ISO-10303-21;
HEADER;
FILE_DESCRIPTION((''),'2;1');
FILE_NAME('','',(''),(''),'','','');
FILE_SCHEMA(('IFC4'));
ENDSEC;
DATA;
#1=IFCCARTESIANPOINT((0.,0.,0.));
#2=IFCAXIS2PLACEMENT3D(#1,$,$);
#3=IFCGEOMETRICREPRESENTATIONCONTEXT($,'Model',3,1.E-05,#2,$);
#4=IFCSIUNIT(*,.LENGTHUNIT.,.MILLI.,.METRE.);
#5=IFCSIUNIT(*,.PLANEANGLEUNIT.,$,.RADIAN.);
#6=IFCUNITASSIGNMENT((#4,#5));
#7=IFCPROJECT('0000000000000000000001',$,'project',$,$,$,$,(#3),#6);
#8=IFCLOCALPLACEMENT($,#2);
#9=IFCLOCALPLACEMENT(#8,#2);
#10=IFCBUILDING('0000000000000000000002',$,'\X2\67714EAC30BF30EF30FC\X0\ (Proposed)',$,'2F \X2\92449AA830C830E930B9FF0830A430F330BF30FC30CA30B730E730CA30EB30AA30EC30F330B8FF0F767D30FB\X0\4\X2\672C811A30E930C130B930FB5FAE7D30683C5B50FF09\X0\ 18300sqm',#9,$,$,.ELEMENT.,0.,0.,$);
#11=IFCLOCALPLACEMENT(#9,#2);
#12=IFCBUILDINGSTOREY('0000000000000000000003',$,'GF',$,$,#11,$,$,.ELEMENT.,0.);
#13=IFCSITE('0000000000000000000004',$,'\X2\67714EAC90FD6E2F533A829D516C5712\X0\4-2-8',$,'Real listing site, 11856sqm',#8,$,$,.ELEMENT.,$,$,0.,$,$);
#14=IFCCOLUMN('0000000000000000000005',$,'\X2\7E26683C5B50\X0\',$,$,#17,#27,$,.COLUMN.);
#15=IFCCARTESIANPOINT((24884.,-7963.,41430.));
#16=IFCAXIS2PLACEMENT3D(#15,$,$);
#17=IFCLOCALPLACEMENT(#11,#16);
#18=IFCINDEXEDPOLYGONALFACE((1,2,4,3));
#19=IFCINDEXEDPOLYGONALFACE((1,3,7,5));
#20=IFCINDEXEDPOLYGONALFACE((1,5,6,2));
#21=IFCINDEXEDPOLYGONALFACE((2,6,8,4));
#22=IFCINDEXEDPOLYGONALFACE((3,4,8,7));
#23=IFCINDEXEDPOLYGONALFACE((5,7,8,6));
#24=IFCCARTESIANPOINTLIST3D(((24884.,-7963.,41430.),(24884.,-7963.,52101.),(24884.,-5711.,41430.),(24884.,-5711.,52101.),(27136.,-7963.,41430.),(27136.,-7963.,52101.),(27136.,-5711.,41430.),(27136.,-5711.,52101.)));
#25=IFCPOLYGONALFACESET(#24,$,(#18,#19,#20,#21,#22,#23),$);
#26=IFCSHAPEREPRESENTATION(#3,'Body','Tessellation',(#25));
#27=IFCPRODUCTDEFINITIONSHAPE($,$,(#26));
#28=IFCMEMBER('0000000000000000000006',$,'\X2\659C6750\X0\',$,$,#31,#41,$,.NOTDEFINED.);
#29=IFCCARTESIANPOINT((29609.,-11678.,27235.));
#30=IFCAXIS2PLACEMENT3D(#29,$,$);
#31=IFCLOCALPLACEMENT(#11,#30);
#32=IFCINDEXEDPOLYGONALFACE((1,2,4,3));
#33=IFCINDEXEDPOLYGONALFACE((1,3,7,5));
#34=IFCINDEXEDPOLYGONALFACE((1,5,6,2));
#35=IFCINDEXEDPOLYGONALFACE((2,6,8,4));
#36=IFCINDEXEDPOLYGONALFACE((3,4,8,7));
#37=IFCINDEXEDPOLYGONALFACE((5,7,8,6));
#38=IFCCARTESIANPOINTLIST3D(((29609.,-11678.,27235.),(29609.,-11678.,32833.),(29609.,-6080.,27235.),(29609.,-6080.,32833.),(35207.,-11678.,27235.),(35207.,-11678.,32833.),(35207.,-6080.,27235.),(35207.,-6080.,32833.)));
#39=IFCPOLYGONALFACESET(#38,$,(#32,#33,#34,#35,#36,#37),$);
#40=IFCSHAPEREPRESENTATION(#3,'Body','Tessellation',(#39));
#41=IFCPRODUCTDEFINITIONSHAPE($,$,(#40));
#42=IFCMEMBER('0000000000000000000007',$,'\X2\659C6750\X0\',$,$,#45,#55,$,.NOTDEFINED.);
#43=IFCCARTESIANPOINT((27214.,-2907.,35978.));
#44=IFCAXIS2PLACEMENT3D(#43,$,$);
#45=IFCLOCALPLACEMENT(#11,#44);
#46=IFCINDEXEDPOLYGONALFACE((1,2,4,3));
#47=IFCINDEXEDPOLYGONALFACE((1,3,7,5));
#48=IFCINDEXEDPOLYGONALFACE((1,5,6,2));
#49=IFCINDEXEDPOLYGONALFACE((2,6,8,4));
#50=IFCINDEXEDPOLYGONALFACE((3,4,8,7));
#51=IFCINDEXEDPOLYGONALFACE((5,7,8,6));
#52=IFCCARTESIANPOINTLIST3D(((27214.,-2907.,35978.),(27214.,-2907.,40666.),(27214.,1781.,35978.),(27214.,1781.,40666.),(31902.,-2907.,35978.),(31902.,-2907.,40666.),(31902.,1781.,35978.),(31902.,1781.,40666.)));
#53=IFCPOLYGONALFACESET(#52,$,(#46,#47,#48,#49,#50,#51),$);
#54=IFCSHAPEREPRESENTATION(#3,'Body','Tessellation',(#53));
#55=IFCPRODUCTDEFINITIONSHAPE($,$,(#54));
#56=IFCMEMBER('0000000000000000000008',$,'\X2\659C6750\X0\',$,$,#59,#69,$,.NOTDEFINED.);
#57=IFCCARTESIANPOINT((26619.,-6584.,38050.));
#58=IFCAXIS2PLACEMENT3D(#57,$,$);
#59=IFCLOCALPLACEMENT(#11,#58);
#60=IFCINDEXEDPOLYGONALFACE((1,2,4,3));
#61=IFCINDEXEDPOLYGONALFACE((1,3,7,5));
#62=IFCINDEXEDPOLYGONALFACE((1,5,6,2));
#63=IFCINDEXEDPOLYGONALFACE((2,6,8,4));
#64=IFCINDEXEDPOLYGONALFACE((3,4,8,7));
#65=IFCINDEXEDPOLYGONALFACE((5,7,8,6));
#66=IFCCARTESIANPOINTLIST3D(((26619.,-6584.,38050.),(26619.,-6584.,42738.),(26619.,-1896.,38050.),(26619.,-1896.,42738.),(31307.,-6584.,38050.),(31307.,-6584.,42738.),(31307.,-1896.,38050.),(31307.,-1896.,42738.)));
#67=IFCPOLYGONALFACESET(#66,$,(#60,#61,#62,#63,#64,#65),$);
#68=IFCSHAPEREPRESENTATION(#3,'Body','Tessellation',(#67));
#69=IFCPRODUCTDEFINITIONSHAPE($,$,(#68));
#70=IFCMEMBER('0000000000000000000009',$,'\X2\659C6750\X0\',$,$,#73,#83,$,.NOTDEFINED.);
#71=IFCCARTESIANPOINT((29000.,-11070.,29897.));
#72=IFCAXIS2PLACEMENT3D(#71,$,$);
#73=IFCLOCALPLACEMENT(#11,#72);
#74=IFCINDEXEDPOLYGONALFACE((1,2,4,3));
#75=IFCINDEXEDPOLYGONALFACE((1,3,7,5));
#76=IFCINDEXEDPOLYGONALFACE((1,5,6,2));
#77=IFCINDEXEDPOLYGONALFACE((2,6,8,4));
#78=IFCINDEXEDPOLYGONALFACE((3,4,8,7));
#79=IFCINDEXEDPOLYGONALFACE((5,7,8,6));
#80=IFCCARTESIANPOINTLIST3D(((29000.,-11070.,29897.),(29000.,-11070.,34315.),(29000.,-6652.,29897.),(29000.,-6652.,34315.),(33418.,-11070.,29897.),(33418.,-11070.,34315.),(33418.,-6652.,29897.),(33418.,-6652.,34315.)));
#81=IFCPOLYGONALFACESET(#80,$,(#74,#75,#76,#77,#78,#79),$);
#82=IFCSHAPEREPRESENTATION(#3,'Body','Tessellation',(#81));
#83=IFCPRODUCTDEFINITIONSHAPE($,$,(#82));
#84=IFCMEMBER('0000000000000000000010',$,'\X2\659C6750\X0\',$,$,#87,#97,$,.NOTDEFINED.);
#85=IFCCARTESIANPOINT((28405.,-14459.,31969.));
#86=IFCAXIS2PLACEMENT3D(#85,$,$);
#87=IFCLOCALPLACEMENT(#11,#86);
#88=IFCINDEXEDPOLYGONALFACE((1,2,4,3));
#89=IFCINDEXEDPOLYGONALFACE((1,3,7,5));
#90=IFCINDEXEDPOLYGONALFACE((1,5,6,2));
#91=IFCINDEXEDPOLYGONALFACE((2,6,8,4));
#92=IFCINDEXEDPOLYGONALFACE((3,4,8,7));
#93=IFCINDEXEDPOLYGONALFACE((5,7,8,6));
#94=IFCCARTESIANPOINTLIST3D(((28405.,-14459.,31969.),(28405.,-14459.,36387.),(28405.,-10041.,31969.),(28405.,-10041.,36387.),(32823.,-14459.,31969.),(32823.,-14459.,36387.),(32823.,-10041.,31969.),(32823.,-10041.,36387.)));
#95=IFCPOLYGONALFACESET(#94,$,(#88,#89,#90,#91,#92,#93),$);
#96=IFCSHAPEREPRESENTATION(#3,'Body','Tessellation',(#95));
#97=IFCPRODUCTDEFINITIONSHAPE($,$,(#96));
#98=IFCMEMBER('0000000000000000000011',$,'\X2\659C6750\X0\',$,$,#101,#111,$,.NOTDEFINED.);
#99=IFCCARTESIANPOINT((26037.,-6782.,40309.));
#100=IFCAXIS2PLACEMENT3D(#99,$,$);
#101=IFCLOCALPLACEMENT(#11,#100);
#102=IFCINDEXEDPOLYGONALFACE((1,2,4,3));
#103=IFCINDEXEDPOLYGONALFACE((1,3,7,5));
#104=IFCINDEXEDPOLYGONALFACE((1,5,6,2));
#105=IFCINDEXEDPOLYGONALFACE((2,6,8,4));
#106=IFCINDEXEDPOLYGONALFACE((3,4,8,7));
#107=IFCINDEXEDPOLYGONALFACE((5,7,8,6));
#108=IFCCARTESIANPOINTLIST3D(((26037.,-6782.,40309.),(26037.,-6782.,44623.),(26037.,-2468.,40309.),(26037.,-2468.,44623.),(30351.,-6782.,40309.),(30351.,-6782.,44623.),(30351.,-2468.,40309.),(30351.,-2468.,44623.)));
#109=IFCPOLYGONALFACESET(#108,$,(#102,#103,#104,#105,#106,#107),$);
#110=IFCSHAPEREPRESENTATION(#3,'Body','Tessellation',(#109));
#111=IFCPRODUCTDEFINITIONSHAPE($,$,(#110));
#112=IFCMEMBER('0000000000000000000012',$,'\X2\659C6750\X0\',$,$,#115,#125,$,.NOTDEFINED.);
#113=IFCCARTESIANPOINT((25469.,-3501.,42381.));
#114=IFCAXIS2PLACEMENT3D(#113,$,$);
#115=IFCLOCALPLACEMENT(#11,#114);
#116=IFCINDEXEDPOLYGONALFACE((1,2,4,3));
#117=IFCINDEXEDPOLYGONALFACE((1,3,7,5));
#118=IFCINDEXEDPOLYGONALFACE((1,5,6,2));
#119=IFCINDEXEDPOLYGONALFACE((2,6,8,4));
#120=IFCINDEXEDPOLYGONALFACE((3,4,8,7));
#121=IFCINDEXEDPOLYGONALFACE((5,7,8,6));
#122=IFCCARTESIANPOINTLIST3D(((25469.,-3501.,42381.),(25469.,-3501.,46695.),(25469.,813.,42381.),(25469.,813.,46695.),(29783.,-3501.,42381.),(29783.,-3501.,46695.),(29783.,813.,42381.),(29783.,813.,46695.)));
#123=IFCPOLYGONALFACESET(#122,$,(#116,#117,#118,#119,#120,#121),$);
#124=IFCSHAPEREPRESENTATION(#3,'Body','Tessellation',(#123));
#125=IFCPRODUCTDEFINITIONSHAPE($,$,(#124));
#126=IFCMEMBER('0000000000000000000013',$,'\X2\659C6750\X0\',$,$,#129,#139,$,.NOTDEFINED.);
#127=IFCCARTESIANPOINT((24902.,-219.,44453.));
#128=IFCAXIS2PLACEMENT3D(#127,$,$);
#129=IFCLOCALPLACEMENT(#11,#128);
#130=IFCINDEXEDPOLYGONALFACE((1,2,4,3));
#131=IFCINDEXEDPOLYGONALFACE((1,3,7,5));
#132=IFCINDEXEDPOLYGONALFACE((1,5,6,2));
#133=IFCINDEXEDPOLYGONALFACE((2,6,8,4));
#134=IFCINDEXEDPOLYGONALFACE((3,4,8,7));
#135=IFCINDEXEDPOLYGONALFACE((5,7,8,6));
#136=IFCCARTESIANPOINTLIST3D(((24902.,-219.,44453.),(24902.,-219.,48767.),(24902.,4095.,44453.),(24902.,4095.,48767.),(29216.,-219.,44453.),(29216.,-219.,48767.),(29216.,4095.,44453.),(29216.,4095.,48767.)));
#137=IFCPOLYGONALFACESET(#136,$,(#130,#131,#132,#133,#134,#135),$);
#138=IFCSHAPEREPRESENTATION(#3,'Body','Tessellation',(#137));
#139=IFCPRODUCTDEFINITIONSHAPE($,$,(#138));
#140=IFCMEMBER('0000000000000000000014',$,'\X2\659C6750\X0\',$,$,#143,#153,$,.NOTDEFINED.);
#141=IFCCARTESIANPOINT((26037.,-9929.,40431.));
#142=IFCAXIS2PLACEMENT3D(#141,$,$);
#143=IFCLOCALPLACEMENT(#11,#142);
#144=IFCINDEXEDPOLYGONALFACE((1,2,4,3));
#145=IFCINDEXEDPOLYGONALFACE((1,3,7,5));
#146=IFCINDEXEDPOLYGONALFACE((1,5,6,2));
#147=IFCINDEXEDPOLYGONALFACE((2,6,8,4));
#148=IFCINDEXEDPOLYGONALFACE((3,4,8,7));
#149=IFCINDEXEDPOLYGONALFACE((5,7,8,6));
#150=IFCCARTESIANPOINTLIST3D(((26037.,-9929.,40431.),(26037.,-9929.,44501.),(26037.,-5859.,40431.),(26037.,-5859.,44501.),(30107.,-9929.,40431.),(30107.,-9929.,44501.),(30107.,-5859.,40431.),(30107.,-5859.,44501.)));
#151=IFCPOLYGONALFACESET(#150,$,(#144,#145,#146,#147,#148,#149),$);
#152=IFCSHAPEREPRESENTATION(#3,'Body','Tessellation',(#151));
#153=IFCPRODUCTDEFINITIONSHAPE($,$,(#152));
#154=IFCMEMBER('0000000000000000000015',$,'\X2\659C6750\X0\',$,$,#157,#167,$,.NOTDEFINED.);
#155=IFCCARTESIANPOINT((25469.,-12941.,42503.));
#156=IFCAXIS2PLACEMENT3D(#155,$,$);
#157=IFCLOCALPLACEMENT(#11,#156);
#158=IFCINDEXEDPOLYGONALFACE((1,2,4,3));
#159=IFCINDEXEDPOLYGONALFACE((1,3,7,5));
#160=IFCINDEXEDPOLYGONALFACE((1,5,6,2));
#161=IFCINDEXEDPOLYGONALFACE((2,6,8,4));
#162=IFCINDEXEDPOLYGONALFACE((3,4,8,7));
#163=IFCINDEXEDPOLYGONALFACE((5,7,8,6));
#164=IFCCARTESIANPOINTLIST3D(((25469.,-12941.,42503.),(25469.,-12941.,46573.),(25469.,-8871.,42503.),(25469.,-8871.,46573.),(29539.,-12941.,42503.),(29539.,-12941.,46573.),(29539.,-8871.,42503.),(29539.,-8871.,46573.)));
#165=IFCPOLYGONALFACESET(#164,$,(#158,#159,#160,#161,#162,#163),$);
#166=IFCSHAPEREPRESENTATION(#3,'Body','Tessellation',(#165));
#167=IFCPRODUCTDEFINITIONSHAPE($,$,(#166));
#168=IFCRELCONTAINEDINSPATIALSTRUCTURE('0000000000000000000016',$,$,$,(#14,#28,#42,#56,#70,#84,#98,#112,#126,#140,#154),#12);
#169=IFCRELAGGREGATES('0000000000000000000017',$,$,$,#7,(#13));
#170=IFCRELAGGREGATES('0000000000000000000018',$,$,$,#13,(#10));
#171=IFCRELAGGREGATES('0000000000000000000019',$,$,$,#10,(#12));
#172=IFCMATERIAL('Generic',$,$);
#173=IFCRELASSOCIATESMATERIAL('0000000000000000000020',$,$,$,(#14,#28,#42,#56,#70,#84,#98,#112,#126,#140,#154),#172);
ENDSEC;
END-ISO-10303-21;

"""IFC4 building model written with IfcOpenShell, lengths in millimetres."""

from ifc_helpers import new_model, si_unit, frame, frame_2d, origin, place, context, project, spatial, rectangle, extrude, material, element, save


model = new_model("IFC4")

# Units and contexts
model_context = context("Model", 3, precision=1e-05, world=origin())
ifc_project = project(units=[si_unit("LENGTHUNIT", "METRE", prefix="MILLI"), si_unit("PLANEANGLEUNIT", "RADIAN")], contexts=[model_context])

# Site, building, storey
site_placement = place(None, origin())
site = spatial("IfcSite", under=ifc_project, at=site_placement, Name="東京都港区芝公園4-2-8", ObjectType="Real listing site, 11856sqm", CompositionType="ELEMENT", RefElevation=0.0)
building_placement = place(site_placement, origin())
building = spatial("IfcBuilding", under=site, at=building_placement, Name="東京タワー (Proposed)", ObjectType="2F 鉄骨トラス（インターナショナルオレンジ／白・4本脚ラチス・微細格子） 18300sqm", CompositionType="ELEMENT", ElevationOfRefHeight=0.0, ElevationOfTerrain=0.0)
storey_placement = place(building_placement, origin())
storey = spatial("IfcBuildingStorey", under=building, at=storey_placement, Name="GF", CompositionType="ELEMENT", Elevation=0.0)

# Column
ifc_material = material(Name="Generic")
column_1_placement = place(storey_placement, frame((24884.0, -7963.0, 41430.0)))
element("IfcColumn", 1, at=column_1_placement, inside=storey, material=ifc_material, Name="縦格子", PredefinedType="COLUMN", context=model_context, shape_type="SweptSolid", body=[
    extrude(rectangle(XDim=2252.0, YDim=2252.0, at=frame_2d((1126.0, 1126.0))), frame((24884.0, -7963.0, 41430.0)), (0.0, 0.0, 1.0), 10671.0),
])

# Members
member_1_placement = place(storey_placement, frame((29609.0, -11678.0, 27235.0)))
element("IfcMember", 2, at=member_1_placement, inside=storey, material=ifc_material, Name="斜材", PredefinedType="NOTDEFINED", context=model_context, shape_type="SweptSolid", body=[
    extrude(rectangle(XDim=5598.0, YDim=5598.0, at=frame_2d((2799.0, 2799.0))), frame((29609.0, -11678.0, 27235.0)), (0.0, 0.0, 1.0), 5598.0),
])
member_2_placement = place(storey_placement, frame((27214.0, -2907.0, 35978.0)))
element("IfcMember", 3, at=member_2_placement, inside=storey, material=ifc_material, Name="斜材", PredefinedType="NOTDEFINED", context=model_context, shape_type="SweptSolid", body=[
    extrude(rectangle(XDim=4688.0, YDim=4688.0, at=frame_2d((2344.0, 2344.0))), frame((27214.0, -2907.0, 35978.0)), (0.0, 0.0, 1.0), 4688.0),
])
member_3_placement = place(storey_placement, frame((26619.0, -6584.0, 38050.0)))
element("IfcMember", 4, at=member_3_placement, inside=storey, material=ifc_material, Name="斜材", PredefinedType="NOTDEFINED", context=model_context, shape_type="SweptSolid", body=[
    extrude(rectangle(XDim=4688.0, YDim=4688.0, at=frame_2d((2344.0, 2344.0))), frame((26619.0, -6584.0, 38050.0)), (0.0, 0.0, 1.0), 4688.0),
])
member_4_placement = place(storey_placement, frame((29000.0, -11070.0, 29897.0)))
element("IfcMember", 5, at=member_4_placement, inside=storey, material=ifc_material, Name="斜材", PredefinedType="NOTDEFINED", context=model_context, shape_type="SweptSolid", body=[
    extrude(rectangle(XDim=4418.0, YDim=4418.0, at=frame_2d((2209.0, 2209.0))), frame((29000.0, -11070.0, 29897.0)), (0.0, 0.0, 1.0), 4418.0),
])
member_5_placement = place(storey_placement, frame((28405.0, -14459.0, 31969.0)))
element("IfcMember", 6, at=member_5_placement, inside=storey, material=ifc_material, Name="斜材", PredefinedType="NOTDEFINED", context=model_context, shape_type="SweptSolid", body=[
    extrude(rectangle(XDim=4418.0, YDim=4418.0, at=frame_2d((2209.0, 2209.0))), frame((28405.0, -14459.0, 31969.0)), (0.0, 0.0, 1.0), 4418.0),
])
member_6_placement = place(storey_placement, frame((26037.0, -6782.0, 40309.0)))
element("IfcMember", 7, at=member_6_placement, inside=storey, material=ifc_material, Name="斜材", PredefinedType="NOTDEFINED", context=model_context, shape_type="SweptSolid", body=[
    extrude(rectangle(XDim=4314.0, YDim=4314.0, at=frame_2d((2157.0, 2157.0))), frame((26037.0, -6782.0, 40309.0)), (0.0, 0.0, 1.0), 4314.0),
])
member_7_placement = place(storey_placement, frame((25469.0, -3501.0, 42381.0)))
element("IfcMember", 8, at=member_7_placement, inside=storey, material=ifc_material, Name="斜材", PredefinedType="NOTDEFINED", context=model_context, shape_type="SweptSolid", body=[
    extrude(rectangle(XDim=4314.0, YDim=4314.0, at=frame_2d((2157.0, 2157.0))), frame((25469.0, -3501.0, 42381.0)), (0.0, 0.0, 1.0), 4314.0),
])
member_8_placement = place(storey_placement, frame((24902.0, -219.0, 44453.0)))
element("IfcMember", 9, at=member_8_placement, inside=storey, material=ifc_material, Name="斜材", PredefinedType="NOTDEFINED", context=model_context, shape_type="SweptSolid", body=[
    extrude(rectangle(XDim=4314.0, YDim=4314.0, at=frame_2d((2157.0, 2157.0))), frame((24902.0, -219.0, 44453.0)), (0.0, 0.0, 1.0), 4314.0),
])
member_9_placement = place(storey_placement, frame((26037.0, -9929.0, 40431.0)))
element("IfcMember", 10, at=member_9_placement, inside=storey, material=ifc_material, Name="斜材", PredefinedType="NOTDEFINED", context=model_context, shape_type="SweptSolid", body=[
    extrude(rectangle(XDim=4070.0, YDim=4070.0, at=frame_2d((2035.0, 2035.0))), frame((26037.0, -9929.0, 40431.0)), (0.0, 0.0, 1.0), 4070.0),
])
member_10_placement = place(storey_placement, frame((25469.0, -12941.0, 42503.0)))
element("IfcMember", 11, at=member_10_placement, inside=storey, material=ifc_material, Name="斜材", PredefinedType="NOTDEFINED", context=model_context, shape_type="SweptSolid", body=[
    extrude(rectangle(XDim=4070.0, YDim=4070.0, at=frame_2d((2035.0, 2035.0))), frame((25469.0, -12941.0, 42503.0)), (0.0, 0.0, 1.0), 4070.0),
])

save(model, "model.ifc")
